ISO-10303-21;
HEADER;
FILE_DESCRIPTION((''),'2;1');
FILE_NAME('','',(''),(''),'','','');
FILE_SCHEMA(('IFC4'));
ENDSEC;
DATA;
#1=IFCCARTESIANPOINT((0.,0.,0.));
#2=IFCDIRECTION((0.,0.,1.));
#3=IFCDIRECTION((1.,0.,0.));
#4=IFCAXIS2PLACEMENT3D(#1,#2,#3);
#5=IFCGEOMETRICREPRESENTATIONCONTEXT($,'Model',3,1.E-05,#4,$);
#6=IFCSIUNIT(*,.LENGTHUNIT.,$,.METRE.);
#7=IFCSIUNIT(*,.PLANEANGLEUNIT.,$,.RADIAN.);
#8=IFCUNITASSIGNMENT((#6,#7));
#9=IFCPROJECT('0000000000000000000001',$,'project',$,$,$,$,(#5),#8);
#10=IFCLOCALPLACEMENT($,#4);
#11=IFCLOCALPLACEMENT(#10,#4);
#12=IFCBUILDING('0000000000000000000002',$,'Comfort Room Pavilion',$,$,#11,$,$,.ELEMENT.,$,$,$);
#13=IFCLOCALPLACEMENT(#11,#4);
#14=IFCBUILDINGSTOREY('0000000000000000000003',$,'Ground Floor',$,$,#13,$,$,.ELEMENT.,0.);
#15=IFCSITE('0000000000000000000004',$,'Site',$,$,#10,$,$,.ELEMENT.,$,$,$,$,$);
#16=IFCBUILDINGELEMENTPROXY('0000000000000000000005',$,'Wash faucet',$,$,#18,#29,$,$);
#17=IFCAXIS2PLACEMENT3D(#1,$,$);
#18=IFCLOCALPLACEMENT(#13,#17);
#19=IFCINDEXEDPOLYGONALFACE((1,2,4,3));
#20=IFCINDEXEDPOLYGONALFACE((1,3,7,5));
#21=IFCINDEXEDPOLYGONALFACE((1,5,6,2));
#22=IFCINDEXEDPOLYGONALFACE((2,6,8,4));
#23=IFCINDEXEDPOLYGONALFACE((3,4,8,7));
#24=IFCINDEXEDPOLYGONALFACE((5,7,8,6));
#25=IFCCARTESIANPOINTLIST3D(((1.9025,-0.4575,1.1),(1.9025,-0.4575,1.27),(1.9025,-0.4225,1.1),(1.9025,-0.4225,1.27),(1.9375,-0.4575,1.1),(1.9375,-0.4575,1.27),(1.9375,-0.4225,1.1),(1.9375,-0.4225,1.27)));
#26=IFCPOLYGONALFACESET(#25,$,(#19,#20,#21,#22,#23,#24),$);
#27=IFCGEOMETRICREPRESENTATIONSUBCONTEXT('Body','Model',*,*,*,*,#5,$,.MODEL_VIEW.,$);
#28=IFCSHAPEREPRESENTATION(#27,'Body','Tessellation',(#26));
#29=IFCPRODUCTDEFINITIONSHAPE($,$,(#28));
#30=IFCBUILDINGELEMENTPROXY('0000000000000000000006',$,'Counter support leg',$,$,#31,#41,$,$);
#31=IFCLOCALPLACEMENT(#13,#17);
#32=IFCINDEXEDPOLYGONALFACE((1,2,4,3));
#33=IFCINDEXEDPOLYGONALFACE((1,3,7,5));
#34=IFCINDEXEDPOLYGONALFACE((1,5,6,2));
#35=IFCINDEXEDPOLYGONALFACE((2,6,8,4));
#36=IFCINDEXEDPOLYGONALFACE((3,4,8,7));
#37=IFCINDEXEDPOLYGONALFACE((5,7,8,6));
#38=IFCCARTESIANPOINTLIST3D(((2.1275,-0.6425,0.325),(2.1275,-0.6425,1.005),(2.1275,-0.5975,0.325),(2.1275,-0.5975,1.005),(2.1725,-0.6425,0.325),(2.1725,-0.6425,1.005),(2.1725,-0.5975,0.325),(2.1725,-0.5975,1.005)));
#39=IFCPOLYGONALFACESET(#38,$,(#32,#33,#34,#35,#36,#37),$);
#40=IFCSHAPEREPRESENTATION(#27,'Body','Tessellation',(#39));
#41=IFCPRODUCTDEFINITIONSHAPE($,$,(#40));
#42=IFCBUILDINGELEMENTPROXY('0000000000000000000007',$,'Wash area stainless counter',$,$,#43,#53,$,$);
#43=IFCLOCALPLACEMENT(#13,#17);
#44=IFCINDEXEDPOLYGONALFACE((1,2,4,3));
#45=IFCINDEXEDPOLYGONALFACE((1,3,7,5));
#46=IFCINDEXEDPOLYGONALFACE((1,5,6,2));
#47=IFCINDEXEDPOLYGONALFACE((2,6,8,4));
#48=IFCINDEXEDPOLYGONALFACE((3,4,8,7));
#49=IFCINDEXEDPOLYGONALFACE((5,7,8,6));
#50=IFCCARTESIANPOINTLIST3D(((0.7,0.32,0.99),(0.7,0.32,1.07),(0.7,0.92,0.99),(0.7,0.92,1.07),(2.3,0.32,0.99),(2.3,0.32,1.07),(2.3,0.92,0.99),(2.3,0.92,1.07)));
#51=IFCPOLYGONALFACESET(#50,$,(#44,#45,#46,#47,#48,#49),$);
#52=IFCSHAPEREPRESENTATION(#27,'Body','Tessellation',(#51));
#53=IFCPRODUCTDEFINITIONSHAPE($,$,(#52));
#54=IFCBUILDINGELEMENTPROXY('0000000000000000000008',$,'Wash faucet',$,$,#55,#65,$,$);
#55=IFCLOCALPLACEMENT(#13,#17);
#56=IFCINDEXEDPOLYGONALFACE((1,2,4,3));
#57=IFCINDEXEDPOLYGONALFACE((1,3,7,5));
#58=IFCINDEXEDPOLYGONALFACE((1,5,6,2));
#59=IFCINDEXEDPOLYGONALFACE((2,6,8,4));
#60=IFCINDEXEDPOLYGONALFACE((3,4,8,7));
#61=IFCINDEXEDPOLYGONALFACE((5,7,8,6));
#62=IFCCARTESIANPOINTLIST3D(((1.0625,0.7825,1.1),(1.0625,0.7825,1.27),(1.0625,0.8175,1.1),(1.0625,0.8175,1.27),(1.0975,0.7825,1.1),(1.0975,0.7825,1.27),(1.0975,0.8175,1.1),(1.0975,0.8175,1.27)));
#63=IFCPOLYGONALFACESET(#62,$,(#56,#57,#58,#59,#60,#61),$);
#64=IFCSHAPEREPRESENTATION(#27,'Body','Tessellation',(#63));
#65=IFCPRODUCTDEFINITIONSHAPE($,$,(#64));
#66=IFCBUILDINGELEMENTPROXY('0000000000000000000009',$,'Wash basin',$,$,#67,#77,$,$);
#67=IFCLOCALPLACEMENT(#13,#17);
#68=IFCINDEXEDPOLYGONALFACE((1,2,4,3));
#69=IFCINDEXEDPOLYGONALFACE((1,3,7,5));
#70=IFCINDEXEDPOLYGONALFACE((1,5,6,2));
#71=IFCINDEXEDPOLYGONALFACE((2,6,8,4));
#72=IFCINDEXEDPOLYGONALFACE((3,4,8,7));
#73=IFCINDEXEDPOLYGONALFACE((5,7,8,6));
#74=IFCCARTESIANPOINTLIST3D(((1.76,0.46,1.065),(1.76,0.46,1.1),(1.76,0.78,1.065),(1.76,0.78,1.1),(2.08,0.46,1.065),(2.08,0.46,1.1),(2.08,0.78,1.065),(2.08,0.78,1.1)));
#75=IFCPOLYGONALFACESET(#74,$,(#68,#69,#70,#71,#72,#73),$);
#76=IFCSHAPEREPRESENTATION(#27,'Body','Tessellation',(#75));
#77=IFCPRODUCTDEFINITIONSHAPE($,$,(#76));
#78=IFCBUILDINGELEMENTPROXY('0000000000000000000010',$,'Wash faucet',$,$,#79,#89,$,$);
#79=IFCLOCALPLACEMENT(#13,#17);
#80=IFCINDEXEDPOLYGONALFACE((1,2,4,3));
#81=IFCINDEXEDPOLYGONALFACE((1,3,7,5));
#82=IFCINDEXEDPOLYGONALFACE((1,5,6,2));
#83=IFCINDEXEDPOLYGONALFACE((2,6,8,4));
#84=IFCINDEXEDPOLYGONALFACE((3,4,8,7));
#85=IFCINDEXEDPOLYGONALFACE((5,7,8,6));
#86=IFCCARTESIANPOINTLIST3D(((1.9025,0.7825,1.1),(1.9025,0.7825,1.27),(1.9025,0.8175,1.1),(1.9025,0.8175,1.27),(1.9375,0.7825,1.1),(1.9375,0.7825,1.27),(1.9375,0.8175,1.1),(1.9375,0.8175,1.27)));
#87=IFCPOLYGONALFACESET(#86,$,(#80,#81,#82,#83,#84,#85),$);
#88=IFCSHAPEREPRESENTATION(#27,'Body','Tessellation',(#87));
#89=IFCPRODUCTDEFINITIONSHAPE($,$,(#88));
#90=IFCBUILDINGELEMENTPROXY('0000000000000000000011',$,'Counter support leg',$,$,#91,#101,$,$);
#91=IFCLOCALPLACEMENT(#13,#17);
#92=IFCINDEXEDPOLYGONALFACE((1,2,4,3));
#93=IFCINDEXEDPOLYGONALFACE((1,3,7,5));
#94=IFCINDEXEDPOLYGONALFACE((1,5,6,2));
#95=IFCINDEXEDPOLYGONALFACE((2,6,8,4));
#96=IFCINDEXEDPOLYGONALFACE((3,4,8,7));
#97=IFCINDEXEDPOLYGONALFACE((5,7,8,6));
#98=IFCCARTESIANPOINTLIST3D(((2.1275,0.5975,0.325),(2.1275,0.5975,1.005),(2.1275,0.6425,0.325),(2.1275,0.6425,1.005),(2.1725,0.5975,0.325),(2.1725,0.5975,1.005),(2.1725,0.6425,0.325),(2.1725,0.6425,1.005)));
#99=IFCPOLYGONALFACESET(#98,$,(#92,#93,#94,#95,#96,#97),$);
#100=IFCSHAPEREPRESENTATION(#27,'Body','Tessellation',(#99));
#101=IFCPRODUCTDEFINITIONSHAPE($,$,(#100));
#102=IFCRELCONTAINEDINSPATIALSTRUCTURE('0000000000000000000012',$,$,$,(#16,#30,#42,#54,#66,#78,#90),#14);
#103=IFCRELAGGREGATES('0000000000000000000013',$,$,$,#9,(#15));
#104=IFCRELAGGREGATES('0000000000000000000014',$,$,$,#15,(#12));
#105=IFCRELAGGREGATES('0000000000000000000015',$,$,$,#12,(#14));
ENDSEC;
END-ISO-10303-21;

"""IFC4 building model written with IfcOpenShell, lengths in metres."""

from ifc_helpers import new_model, si_unit, frame, origin_with_axes, origin_2d, place, context, subcontext, project, spatial, rectangle, extrude, element, save


model = new_model("IFC4")

# Units and contexts
model_context = context("Model", 3, precision=1e-05, world=origin_with_axes())
body_context = subcontext(model_context, "Body", "Model", "MODEL_VIEW")
ifc_project = project(units=[si_unit("LENGTHUNIT", "METRE"), si_unit("PLANEANGLEUNIT", "RADIAN")], contexts=[model_context])

# Site, building, storey
site_placement = place(None, origin_with_axes())
site = spatial("IfcSite", under=ifc_project, at=site_placement, Name="Site", CompositionType="ELEMENT")
building_placement = place(site_placement, origin_with_axes())
building = spatial("IfcBuilding", under=site, at=building_placement, Name="Comfort Room Pavilion", CompositionType="ELEMENT")
storey_placement = place(building_placement, origin_with_axes())
storey = spatial("IfcBuildingStorey", under=building, at=storey_placement, Name="Ground Floor", CompositionType="ELEMENT", Elevation=0.0)

# Building element proxies
proxy_1_placement = place(storey_placement, frame((1.92, -0.44, 1.1), z_axis=(0.0, 0.0, 1.0), x_axis=(1.0, 0.0, 0.0)))
element("IfcBuildingElementProxy", 1, at=proxy_1_placement, inside=storey, Name="Wash faucet", context=body_context, shape_type="SweptSolid", body=[
    extrude(rectangle(XDim=0.035, YDim=0.035, at=origin_2d()), origin_with_axes(), (0.0, 0.0, 1.0), 0.17),
])
proxy_2_placement = place(storey_placement, frame((2.15, -0.62, 0.325), z_axis=(0.0, 0.0, 1.0), x_axis=(1.0, 0.0, 0.0)))
element("IfcBuildingElementProxy", 2, at=proxy_2_placement, inside=storey, Name="Counter support leg", context=body_context, shape_type="SweptSolid", body=[
    extrude(rectangle(XDim=0.045, YDim=0.045, at=origin_2d()), origin_with_axes(), (0.0, 0.0, 1.0), 0.68),
])
proxy_3_placement = place(storey_placement, frame((1.5, 0.62, 0.99), z_axis=(0.0, 0.0, 1.0), x_axis=(1.0, 0.0, 0.0)))
element("IfcBuildingElementProxy", 3, at=proxy_3_placement, inside=storey, Name="Wash area stainless counter", context=body_context, shape_type="SweptSolid", body=[
    extrude(rectangle(XDim=1.6, YDim=0.6, at=origin_2d()), origin_with_axes(), (0.0, 0.0, 1.0), 0.08),
])
proxy_4_placement = place(storey_placement, frame((1.08, 0.8, 1.1), z_axis=(0.0, 0.0, 1.0), x_axis=(1.0, 0.0, 0.0)))
element("IfcBuildingElementProxy", 4, at=proxy_4_placement, inside=storey, Name="Wash faucet", context=body_context, shape_type="SweptSolid", body=[
    extrude(rectangle(XDim=0.035, YDim=0.035, at=origin_2d()), origin_with_axes(), (0.0, 0.0, 1.0), 0.17),
])
proxy_5_placement = place(storey_placement, frame((1.92, 0.62, 1.065), z_axis=(0.0, 0.0, 1.0), x_axis=(1.0, 0.0, 0.0)))
element("IfcBuildingElementProxy", 5, at=proxy_5_placement, inside=storey, Name="Wash basin", context=body_context, shape_type="SweptSolid", body=[
    extrude(rectangle(XDim=0.32, YDim=0.32, at=origin_2d()), origin_with_axes(), (0.0, 0.0, 1.0), 0.035),
])
proxy_6_placement = place(storey_placement, frame((1.92, 0.8, 1.1), z_axis=(0.0, 0.0, 1.0), x_axis=(1.0, 0.0, 0.0)))
element("IfcBuildingElementProxy", 6, at=proxy_6_placement, inside=storey, Name="Wash faucet", context=body_context, shape_type="SweptSolid", body=[
    extrude(rectangle(XDim=0.035, YDim=0.035, at=origin_2d()), origin_with_axes(), (0.0, 0.0, 1.0), 0.17),
])
proxy_7_placement = place(storey_placement, frame((2.15, 0.62, 0.325), z_axis=(0.0, 0.0, 1.0), x_axis=(1.0, 0.0, 0.0)))
element("IfcBuildingElementProxy", 7, at=proxy_7_placement, inside=storey, Name="Counter support leg", context=body_context, shape_type="SweptSolid", body=[
    extrude(rectangle(XDim=0.045, YDim=0.045, at=origin_2d()), origin_with_axes(), (0.0, 0.0, 1.0), 0.68),
])

save(model, "model.ifc")
